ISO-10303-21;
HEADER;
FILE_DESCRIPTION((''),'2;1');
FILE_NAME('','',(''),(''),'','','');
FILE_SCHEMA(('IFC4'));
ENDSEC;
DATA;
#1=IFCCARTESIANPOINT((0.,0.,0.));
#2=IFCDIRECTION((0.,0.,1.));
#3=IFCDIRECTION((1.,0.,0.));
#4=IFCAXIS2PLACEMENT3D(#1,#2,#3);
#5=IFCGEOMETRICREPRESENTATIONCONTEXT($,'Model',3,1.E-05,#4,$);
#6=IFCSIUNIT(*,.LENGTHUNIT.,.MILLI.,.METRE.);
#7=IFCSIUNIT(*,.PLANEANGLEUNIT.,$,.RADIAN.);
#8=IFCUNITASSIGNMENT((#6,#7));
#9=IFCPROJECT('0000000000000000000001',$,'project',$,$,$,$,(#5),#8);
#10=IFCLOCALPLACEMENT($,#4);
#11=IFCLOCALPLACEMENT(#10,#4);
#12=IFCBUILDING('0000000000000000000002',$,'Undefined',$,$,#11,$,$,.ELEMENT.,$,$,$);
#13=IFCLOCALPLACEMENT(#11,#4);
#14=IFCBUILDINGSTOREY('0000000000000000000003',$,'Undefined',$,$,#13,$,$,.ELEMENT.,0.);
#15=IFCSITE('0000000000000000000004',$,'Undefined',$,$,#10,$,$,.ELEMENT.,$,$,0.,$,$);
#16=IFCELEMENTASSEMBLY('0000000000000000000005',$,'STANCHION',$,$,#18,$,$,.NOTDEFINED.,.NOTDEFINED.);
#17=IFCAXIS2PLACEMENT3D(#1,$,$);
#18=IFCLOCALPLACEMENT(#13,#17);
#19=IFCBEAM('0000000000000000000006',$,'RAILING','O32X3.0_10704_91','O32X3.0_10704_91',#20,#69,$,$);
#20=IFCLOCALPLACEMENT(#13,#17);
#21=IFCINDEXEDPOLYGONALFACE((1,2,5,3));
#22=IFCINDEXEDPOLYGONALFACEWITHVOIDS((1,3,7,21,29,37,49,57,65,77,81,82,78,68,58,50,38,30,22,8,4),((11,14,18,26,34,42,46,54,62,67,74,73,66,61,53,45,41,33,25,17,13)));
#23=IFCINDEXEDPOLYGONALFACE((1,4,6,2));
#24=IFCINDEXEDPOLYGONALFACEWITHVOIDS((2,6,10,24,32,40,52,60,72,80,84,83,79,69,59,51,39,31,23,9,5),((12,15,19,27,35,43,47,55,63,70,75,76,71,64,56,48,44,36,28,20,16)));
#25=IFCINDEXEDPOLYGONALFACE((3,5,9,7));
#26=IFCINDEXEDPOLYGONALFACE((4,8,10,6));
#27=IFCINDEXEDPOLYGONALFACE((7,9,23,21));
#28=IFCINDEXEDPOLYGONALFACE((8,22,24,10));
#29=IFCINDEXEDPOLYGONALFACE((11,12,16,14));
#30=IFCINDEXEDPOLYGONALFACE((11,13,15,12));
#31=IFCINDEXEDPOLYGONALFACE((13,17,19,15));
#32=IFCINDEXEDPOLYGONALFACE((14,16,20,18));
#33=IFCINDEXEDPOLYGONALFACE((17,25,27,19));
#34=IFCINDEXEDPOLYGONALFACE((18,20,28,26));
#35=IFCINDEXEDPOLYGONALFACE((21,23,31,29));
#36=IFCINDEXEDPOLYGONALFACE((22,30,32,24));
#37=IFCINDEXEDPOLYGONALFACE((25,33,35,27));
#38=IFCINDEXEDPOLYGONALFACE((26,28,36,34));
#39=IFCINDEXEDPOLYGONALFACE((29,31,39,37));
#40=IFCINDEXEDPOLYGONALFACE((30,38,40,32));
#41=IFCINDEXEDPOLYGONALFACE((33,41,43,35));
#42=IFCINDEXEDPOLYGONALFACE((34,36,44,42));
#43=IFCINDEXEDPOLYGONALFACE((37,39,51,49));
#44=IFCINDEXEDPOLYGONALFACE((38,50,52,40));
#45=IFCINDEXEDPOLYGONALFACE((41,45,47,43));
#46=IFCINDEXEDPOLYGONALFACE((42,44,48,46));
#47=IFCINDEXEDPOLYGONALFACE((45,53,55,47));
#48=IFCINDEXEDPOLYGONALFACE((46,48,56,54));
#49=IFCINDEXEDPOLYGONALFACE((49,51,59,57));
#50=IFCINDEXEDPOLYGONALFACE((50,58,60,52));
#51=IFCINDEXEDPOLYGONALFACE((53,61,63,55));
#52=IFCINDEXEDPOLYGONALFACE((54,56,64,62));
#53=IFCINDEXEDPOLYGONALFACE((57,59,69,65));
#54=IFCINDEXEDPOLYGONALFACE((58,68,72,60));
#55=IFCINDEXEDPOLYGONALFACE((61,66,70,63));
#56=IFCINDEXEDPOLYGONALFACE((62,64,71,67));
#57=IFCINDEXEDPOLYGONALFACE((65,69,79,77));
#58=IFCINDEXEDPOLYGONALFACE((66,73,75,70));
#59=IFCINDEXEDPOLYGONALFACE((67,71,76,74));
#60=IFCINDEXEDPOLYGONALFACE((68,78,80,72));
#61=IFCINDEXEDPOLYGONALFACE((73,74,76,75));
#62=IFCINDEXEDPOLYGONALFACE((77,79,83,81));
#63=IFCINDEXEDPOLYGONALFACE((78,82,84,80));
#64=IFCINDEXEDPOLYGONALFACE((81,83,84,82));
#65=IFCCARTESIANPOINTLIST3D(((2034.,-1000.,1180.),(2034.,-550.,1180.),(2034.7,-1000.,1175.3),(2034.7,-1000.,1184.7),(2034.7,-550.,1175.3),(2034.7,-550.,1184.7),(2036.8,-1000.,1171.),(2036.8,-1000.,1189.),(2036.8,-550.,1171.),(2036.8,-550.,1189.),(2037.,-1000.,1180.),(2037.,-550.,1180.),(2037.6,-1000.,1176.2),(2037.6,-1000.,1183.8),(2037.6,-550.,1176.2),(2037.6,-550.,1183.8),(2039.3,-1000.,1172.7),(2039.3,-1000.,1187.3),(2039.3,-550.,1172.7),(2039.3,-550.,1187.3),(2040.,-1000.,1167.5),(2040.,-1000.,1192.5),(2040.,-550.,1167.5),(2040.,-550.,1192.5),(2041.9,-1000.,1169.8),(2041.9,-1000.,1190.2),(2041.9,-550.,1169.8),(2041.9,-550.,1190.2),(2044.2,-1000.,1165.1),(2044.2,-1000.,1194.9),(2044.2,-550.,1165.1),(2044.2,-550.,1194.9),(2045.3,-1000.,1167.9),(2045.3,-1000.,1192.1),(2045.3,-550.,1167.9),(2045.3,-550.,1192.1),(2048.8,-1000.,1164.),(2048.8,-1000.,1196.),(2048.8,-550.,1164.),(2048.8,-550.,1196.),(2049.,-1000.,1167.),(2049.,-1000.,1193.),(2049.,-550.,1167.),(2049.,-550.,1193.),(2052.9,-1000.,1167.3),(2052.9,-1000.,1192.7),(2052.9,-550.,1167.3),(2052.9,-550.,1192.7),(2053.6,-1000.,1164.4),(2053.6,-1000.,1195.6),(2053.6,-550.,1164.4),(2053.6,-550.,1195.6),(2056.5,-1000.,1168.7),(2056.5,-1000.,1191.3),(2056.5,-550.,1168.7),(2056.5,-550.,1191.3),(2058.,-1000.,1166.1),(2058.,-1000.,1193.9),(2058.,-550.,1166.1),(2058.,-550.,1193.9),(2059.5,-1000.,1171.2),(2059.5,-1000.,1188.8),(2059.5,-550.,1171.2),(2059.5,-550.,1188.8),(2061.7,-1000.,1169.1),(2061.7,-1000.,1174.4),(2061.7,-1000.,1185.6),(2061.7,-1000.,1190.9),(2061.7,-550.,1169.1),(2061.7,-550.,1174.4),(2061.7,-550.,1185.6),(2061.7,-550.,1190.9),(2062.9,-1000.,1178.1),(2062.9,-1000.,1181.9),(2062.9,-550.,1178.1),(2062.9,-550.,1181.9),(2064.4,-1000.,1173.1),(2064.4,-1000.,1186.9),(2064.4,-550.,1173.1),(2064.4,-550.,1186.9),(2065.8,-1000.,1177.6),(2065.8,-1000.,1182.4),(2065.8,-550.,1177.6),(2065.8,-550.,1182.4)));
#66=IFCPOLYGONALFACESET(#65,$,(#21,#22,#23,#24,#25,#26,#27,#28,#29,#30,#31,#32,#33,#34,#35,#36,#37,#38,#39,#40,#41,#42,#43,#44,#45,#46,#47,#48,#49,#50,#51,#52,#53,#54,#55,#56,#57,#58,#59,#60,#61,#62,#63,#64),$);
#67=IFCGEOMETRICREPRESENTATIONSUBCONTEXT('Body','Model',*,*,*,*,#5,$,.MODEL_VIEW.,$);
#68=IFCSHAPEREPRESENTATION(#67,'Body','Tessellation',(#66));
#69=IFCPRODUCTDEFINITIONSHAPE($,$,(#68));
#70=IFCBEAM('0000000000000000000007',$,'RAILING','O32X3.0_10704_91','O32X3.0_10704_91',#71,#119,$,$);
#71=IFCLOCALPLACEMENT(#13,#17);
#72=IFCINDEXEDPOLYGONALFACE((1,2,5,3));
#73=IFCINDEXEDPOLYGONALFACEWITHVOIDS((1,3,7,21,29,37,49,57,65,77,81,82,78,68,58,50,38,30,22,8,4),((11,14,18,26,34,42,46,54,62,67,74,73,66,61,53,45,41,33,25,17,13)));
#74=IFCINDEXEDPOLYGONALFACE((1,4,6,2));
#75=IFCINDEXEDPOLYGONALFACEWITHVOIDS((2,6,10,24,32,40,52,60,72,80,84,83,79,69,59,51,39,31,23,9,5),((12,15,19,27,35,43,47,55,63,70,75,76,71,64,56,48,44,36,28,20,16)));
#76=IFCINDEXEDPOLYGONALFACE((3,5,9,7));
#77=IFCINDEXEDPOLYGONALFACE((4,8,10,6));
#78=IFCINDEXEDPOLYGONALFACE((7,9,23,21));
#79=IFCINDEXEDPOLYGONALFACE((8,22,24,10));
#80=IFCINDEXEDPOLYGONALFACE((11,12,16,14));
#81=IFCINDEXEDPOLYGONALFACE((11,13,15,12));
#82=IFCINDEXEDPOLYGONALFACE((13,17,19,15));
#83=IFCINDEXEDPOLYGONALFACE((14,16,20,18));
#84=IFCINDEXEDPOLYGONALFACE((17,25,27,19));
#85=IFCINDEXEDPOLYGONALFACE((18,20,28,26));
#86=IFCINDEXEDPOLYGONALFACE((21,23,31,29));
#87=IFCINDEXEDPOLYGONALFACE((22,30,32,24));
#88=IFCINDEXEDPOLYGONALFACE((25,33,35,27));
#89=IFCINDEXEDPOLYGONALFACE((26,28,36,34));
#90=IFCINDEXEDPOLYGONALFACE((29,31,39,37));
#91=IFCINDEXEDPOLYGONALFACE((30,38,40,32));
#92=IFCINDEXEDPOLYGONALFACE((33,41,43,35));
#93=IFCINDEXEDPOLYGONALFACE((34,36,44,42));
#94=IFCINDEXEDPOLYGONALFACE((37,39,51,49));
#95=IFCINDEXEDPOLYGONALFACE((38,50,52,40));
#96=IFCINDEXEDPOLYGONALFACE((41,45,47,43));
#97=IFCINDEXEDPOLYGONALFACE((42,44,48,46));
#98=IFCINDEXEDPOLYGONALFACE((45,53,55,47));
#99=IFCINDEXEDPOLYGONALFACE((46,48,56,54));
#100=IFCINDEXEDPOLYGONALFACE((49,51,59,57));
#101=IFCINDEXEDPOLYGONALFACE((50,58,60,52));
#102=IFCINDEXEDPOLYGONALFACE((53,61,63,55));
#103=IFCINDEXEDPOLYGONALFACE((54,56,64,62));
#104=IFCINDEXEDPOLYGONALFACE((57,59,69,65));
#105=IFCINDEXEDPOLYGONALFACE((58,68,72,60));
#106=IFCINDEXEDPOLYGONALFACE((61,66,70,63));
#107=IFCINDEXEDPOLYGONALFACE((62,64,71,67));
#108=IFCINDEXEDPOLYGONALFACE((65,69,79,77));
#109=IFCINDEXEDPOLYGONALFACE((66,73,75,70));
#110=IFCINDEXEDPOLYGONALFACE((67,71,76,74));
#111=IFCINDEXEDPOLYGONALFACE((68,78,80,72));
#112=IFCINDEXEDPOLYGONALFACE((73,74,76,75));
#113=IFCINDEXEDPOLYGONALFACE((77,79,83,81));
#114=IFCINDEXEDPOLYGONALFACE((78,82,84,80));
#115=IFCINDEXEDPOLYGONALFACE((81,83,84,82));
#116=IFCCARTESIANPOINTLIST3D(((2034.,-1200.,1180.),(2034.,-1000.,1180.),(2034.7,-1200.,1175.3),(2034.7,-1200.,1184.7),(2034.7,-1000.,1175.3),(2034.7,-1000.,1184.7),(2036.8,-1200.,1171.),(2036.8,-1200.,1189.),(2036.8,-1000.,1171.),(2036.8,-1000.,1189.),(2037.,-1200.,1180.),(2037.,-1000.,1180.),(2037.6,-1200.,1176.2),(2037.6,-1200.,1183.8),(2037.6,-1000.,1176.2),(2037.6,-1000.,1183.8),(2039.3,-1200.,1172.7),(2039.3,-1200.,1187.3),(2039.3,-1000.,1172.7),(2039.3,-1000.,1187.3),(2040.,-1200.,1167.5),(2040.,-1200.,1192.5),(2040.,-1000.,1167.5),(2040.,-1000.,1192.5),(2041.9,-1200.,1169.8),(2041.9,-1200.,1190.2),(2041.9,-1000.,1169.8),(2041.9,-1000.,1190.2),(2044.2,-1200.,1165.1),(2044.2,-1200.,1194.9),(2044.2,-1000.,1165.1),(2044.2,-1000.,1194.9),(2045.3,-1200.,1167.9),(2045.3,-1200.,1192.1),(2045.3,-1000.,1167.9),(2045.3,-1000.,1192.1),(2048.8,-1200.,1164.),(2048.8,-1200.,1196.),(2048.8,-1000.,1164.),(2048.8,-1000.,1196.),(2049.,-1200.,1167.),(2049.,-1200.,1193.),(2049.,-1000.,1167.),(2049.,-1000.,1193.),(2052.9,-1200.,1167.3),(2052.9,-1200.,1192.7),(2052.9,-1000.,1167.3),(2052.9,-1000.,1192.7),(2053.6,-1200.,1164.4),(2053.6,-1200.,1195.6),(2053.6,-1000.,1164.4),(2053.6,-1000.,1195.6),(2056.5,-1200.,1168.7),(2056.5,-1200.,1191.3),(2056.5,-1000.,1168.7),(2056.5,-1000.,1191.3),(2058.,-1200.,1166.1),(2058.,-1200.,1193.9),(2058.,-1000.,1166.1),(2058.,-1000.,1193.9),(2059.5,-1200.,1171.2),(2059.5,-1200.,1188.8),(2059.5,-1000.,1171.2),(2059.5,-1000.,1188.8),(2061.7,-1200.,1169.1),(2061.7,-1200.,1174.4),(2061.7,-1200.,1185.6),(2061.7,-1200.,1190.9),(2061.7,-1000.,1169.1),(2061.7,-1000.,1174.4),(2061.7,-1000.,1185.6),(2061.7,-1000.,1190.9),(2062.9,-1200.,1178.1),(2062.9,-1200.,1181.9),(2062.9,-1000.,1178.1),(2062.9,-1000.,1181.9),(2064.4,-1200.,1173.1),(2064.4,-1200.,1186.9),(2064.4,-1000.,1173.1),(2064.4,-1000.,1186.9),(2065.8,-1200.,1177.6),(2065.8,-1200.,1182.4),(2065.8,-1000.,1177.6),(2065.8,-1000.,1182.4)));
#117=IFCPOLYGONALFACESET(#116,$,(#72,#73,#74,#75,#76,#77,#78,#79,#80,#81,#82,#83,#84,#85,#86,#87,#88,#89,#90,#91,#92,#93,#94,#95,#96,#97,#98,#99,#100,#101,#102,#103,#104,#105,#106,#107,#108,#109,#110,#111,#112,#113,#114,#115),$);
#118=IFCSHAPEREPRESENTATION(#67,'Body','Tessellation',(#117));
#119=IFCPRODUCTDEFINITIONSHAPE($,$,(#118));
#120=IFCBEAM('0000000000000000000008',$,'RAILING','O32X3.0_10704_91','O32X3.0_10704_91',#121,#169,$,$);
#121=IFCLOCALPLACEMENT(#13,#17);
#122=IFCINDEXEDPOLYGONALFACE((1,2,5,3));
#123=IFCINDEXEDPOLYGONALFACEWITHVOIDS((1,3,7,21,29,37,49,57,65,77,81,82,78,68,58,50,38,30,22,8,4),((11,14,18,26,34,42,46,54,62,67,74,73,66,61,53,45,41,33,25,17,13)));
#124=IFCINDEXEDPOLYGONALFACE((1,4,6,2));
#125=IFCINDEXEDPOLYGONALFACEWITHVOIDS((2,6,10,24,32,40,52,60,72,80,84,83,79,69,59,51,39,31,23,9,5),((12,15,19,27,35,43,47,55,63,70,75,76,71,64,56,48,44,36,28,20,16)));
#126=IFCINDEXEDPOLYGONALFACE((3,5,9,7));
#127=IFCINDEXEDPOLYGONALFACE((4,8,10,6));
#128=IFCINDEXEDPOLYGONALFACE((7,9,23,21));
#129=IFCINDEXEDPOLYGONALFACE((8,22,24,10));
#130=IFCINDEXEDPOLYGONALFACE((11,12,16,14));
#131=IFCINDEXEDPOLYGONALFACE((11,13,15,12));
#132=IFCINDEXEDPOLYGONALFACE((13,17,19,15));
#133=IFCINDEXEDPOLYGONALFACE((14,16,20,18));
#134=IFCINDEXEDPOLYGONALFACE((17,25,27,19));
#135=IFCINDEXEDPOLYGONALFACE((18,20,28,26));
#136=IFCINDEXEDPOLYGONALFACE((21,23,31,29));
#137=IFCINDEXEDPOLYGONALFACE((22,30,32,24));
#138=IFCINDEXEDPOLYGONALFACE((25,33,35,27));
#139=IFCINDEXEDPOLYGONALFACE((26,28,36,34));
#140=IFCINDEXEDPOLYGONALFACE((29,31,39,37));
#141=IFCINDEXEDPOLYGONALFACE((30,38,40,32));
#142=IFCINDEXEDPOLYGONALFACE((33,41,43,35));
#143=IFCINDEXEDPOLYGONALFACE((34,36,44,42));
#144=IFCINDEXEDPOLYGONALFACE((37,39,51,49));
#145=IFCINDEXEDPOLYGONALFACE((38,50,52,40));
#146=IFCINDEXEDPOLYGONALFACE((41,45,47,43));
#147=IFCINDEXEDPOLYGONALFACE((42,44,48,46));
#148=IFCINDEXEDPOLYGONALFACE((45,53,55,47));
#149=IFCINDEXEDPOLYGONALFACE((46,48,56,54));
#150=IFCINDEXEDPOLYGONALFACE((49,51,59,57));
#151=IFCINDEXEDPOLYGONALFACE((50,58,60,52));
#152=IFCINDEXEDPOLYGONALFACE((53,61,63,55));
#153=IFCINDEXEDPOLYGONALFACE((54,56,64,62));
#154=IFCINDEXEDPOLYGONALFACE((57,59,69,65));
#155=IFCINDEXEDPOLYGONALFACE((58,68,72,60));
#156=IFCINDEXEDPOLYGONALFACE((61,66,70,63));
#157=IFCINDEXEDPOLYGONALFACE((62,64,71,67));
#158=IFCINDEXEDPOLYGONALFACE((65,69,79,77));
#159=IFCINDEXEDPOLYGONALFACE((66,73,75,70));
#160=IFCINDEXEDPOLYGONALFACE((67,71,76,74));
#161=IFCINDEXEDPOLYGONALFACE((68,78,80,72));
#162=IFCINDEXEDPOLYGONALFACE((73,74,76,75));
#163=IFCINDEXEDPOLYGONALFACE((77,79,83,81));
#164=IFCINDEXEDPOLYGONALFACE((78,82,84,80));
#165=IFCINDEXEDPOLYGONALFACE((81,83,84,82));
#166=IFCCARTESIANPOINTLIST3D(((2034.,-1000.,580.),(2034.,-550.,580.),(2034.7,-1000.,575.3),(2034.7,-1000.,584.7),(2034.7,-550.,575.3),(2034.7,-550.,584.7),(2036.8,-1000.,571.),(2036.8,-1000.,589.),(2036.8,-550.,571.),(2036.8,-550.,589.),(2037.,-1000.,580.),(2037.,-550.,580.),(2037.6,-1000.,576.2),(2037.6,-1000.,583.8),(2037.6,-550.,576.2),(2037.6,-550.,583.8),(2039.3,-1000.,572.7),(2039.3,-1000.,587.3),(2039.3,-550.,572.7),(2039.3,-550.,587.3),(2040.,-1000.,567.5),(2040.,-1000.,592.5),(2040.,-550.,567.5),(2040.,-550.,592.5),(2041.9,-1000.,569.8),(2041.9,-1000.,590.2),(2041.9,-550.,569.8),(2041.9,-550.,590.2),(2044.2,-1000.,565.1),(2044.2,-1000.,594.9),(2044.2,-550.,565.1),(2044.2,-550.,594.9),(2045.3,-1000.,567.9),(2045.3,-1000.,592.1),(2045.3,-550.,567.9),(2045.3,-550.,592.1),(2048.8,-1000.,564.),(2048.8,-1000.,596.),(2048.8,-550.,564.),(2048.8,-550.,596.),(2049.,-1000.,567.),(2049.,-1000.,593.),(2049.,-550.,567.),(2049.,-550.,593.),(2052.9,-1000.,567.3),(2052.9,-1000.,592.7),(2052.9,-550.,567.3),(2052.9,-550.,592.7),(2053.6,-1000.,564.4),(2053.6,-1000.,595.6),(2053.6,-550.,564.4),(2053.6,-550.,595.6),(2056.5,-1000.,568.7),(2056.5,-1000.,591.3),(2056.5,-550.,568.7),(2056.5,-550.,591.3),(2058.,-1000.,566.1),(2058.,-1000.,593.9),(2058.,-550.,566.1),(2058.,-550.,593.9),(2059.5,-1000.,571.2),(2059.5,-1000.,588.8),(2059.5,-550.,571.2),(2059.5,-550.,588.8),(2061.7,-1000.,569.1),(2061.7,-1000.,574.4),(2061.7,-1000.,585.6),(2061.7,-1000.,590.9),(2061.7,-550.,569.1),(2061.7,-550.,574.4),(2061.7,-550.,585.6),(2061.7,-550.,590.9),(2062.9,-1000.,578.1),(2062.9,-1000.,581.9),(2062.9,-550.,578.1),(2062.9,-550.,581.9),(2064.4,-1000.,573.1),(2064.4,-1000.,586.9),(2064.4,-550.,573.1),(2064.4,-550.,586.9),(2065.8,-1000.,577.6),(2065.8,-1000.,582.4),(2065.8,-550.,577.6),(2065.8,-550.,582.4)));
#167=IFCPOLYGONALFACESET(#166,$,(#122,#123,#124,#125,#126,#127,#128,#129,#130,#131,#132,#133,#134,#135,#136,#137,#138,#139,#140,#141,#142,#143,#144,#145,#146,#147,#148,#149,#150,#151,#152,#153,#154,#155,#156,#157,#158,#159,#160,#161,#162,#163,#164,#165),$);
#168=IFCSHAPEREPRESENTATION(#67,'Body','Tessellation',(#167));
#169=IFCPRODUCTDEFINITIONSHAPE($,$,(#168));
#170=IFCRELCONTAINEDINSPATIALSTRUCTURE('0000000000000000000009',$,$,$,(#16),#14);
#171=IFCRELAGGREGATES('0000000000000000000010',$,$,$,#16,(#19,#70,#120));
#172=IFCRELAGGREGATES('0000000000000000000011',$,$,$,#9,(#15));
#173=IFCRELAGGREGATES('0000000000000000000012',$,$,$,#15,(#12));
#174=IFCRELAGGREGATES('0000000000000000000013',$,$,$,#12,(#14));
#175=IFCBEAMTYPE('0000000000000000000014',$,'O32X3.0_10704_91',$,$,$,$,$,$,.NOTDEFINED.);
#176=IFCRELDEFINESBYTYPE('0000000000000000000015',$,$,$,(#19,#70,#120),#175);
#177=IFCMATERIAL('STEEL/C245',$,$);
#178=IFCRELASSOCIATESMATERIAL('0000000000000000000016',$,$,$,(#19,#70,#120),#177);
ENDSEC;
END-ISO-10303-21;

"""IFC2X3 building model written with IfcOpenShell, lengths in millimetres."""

from ifc_helpers import new_model, si_unit, frame, origin_with_axes, origin_2d_with_axis, place, context, subcontext, project, spatial, hollow_circle, extrude, material, type_object, element, aggregate, save


model = new_model("IFC2X3")

# Units and contexts
model_context = context("Model", 3, precision=1e-05, world=origin_with_axes())
body_context = subcontext(model_context, "Body", "Model", "MODEL_VIEW")
ifc_project = project(units=[si_unit("LENGTHUNIT", "METRE", prefix="MILLI"), si_unit("PLANEANGLEUNIT", "RADIAN")], contexts=[model_context])

# Site, building, storey
site_placement = place(None, origin_with_axes())
site = spatial("IfcSite", under=ifc_project, at=site_placement, Name="Undefined", CompositionType="ELEMENT", RefElevation=0.0)
building_placement = place(site_placement, origin_with_axes())
building = spatial("IfcBuilding", under=site, at=building_placement, Name="Undefined", CompositionType="ELEMENT")
storey_placement = place(building_placement, origin_with_axes())
storey = spatial("IfcBuildingStorey", under=building, at=storey_placement, Name="Undefined", CompositionType="ELEMENT", Elevation=0.0)

# Element assembly
assembly_1_placement = place(storey_placement, origin_with_axes())
assembly_1 = element("IfcElementAssembly", 1, at=assembly_1_placement, inside=storey, Name="STANCHION", AssemblyPlace="NOTDEFINED", PredefinedType="NOTDEFINED")
ifc_material_1 = material(Name="STEEL/C245")

# Beams
beam_type_1 = type_object("IfcBeamType", Name="O32X3.0_10704_91", PredefinedType="NOTDEFINED")
beam_1_placement = place(assembly_1_placement, frame((2050.0, -1000.0, 1180.0), z_axis=(0.0, 0.0, -1.0), x_axis=(0.0, 1.0, 0.0)))
beam_1 = element("IfcBeam", 2, at=beam_1_placement, type_object=beam_type_1, material=ifc_material_1, Name="RAILING", Description="O32X3.0_10704_91", ObjectType="O32X3.0_10704_91", context=body_context, shape_type="SweptSolid", body=[
    extrude(hollow_circle(Radius=16.0, WallThickness=3.0, at=origin_2d_with_axis()), frame((450.0, 0.0, 0.0), z_axis=(-1.0, 0.0, 0.0), x_axis=(0.0, -1.0, 0.0)), (0.0, 0.0, 1.0), 450.0),
])
beam_2_placement = place(assembly_1_placement, frame((2050.0, -1200.0, 1180.0), z_axis=(0.0, 0.0, -1.0), x_axis=(0.0, 1.0, 0.0)))
beam_2 = element("IfcBeam", 3, at=beam_2_placement, type_object=beam_type_1, material=ifc_material_1, Name="RAILING", Description="O32X3.0_10704_91", ObjectType="O32X3.0_10704_91", context=body_context, shape_type="SweptSolid", body=[
    extrude(hollow_circle(Radius=16.0, WallThickness=3.0, at=origin_2d_with_axis()), frame((200.0, 0.0, 0.0), z_axis=(-1.0, 0.0, 0.0), x_axis=(0.0, -1.0, 0.0)), (0.0, 0.0, 1.0), 200.0),
])
beam_3_placement = place(assembly_1_placement, frame((2050.0, -1000.0, 580.0), z_axis=(0.0, 0.0, -1.0), x_axis=(0.0, 1.0, 0.0)))
beam_3 = element("IfcBeam", 4, at=beam_3_placement, type_object=beam_type_1, material=ifc_material_1, Name="RAILING", Description="O32X3.0_10704_91", ObjectType="O32X3.0_10704_91", context=body_context, shape_type="SweptSolid", body=[
    extrude(hollow_circle(Radius=16.0, WallThickness=3.0, at=origin_2d_with_axis()), frame((450.0, 0.0, 0.0), z_axis=(-1.0, 0.0, 0.0), x_axis=(0.0, -1.0, 0.0)), (0.0, 0.0, 1.0), 450.0),
])
aggregate(assembly_1, [beam_1, beam_2, beam_3])

save(model, "model.ifc")
